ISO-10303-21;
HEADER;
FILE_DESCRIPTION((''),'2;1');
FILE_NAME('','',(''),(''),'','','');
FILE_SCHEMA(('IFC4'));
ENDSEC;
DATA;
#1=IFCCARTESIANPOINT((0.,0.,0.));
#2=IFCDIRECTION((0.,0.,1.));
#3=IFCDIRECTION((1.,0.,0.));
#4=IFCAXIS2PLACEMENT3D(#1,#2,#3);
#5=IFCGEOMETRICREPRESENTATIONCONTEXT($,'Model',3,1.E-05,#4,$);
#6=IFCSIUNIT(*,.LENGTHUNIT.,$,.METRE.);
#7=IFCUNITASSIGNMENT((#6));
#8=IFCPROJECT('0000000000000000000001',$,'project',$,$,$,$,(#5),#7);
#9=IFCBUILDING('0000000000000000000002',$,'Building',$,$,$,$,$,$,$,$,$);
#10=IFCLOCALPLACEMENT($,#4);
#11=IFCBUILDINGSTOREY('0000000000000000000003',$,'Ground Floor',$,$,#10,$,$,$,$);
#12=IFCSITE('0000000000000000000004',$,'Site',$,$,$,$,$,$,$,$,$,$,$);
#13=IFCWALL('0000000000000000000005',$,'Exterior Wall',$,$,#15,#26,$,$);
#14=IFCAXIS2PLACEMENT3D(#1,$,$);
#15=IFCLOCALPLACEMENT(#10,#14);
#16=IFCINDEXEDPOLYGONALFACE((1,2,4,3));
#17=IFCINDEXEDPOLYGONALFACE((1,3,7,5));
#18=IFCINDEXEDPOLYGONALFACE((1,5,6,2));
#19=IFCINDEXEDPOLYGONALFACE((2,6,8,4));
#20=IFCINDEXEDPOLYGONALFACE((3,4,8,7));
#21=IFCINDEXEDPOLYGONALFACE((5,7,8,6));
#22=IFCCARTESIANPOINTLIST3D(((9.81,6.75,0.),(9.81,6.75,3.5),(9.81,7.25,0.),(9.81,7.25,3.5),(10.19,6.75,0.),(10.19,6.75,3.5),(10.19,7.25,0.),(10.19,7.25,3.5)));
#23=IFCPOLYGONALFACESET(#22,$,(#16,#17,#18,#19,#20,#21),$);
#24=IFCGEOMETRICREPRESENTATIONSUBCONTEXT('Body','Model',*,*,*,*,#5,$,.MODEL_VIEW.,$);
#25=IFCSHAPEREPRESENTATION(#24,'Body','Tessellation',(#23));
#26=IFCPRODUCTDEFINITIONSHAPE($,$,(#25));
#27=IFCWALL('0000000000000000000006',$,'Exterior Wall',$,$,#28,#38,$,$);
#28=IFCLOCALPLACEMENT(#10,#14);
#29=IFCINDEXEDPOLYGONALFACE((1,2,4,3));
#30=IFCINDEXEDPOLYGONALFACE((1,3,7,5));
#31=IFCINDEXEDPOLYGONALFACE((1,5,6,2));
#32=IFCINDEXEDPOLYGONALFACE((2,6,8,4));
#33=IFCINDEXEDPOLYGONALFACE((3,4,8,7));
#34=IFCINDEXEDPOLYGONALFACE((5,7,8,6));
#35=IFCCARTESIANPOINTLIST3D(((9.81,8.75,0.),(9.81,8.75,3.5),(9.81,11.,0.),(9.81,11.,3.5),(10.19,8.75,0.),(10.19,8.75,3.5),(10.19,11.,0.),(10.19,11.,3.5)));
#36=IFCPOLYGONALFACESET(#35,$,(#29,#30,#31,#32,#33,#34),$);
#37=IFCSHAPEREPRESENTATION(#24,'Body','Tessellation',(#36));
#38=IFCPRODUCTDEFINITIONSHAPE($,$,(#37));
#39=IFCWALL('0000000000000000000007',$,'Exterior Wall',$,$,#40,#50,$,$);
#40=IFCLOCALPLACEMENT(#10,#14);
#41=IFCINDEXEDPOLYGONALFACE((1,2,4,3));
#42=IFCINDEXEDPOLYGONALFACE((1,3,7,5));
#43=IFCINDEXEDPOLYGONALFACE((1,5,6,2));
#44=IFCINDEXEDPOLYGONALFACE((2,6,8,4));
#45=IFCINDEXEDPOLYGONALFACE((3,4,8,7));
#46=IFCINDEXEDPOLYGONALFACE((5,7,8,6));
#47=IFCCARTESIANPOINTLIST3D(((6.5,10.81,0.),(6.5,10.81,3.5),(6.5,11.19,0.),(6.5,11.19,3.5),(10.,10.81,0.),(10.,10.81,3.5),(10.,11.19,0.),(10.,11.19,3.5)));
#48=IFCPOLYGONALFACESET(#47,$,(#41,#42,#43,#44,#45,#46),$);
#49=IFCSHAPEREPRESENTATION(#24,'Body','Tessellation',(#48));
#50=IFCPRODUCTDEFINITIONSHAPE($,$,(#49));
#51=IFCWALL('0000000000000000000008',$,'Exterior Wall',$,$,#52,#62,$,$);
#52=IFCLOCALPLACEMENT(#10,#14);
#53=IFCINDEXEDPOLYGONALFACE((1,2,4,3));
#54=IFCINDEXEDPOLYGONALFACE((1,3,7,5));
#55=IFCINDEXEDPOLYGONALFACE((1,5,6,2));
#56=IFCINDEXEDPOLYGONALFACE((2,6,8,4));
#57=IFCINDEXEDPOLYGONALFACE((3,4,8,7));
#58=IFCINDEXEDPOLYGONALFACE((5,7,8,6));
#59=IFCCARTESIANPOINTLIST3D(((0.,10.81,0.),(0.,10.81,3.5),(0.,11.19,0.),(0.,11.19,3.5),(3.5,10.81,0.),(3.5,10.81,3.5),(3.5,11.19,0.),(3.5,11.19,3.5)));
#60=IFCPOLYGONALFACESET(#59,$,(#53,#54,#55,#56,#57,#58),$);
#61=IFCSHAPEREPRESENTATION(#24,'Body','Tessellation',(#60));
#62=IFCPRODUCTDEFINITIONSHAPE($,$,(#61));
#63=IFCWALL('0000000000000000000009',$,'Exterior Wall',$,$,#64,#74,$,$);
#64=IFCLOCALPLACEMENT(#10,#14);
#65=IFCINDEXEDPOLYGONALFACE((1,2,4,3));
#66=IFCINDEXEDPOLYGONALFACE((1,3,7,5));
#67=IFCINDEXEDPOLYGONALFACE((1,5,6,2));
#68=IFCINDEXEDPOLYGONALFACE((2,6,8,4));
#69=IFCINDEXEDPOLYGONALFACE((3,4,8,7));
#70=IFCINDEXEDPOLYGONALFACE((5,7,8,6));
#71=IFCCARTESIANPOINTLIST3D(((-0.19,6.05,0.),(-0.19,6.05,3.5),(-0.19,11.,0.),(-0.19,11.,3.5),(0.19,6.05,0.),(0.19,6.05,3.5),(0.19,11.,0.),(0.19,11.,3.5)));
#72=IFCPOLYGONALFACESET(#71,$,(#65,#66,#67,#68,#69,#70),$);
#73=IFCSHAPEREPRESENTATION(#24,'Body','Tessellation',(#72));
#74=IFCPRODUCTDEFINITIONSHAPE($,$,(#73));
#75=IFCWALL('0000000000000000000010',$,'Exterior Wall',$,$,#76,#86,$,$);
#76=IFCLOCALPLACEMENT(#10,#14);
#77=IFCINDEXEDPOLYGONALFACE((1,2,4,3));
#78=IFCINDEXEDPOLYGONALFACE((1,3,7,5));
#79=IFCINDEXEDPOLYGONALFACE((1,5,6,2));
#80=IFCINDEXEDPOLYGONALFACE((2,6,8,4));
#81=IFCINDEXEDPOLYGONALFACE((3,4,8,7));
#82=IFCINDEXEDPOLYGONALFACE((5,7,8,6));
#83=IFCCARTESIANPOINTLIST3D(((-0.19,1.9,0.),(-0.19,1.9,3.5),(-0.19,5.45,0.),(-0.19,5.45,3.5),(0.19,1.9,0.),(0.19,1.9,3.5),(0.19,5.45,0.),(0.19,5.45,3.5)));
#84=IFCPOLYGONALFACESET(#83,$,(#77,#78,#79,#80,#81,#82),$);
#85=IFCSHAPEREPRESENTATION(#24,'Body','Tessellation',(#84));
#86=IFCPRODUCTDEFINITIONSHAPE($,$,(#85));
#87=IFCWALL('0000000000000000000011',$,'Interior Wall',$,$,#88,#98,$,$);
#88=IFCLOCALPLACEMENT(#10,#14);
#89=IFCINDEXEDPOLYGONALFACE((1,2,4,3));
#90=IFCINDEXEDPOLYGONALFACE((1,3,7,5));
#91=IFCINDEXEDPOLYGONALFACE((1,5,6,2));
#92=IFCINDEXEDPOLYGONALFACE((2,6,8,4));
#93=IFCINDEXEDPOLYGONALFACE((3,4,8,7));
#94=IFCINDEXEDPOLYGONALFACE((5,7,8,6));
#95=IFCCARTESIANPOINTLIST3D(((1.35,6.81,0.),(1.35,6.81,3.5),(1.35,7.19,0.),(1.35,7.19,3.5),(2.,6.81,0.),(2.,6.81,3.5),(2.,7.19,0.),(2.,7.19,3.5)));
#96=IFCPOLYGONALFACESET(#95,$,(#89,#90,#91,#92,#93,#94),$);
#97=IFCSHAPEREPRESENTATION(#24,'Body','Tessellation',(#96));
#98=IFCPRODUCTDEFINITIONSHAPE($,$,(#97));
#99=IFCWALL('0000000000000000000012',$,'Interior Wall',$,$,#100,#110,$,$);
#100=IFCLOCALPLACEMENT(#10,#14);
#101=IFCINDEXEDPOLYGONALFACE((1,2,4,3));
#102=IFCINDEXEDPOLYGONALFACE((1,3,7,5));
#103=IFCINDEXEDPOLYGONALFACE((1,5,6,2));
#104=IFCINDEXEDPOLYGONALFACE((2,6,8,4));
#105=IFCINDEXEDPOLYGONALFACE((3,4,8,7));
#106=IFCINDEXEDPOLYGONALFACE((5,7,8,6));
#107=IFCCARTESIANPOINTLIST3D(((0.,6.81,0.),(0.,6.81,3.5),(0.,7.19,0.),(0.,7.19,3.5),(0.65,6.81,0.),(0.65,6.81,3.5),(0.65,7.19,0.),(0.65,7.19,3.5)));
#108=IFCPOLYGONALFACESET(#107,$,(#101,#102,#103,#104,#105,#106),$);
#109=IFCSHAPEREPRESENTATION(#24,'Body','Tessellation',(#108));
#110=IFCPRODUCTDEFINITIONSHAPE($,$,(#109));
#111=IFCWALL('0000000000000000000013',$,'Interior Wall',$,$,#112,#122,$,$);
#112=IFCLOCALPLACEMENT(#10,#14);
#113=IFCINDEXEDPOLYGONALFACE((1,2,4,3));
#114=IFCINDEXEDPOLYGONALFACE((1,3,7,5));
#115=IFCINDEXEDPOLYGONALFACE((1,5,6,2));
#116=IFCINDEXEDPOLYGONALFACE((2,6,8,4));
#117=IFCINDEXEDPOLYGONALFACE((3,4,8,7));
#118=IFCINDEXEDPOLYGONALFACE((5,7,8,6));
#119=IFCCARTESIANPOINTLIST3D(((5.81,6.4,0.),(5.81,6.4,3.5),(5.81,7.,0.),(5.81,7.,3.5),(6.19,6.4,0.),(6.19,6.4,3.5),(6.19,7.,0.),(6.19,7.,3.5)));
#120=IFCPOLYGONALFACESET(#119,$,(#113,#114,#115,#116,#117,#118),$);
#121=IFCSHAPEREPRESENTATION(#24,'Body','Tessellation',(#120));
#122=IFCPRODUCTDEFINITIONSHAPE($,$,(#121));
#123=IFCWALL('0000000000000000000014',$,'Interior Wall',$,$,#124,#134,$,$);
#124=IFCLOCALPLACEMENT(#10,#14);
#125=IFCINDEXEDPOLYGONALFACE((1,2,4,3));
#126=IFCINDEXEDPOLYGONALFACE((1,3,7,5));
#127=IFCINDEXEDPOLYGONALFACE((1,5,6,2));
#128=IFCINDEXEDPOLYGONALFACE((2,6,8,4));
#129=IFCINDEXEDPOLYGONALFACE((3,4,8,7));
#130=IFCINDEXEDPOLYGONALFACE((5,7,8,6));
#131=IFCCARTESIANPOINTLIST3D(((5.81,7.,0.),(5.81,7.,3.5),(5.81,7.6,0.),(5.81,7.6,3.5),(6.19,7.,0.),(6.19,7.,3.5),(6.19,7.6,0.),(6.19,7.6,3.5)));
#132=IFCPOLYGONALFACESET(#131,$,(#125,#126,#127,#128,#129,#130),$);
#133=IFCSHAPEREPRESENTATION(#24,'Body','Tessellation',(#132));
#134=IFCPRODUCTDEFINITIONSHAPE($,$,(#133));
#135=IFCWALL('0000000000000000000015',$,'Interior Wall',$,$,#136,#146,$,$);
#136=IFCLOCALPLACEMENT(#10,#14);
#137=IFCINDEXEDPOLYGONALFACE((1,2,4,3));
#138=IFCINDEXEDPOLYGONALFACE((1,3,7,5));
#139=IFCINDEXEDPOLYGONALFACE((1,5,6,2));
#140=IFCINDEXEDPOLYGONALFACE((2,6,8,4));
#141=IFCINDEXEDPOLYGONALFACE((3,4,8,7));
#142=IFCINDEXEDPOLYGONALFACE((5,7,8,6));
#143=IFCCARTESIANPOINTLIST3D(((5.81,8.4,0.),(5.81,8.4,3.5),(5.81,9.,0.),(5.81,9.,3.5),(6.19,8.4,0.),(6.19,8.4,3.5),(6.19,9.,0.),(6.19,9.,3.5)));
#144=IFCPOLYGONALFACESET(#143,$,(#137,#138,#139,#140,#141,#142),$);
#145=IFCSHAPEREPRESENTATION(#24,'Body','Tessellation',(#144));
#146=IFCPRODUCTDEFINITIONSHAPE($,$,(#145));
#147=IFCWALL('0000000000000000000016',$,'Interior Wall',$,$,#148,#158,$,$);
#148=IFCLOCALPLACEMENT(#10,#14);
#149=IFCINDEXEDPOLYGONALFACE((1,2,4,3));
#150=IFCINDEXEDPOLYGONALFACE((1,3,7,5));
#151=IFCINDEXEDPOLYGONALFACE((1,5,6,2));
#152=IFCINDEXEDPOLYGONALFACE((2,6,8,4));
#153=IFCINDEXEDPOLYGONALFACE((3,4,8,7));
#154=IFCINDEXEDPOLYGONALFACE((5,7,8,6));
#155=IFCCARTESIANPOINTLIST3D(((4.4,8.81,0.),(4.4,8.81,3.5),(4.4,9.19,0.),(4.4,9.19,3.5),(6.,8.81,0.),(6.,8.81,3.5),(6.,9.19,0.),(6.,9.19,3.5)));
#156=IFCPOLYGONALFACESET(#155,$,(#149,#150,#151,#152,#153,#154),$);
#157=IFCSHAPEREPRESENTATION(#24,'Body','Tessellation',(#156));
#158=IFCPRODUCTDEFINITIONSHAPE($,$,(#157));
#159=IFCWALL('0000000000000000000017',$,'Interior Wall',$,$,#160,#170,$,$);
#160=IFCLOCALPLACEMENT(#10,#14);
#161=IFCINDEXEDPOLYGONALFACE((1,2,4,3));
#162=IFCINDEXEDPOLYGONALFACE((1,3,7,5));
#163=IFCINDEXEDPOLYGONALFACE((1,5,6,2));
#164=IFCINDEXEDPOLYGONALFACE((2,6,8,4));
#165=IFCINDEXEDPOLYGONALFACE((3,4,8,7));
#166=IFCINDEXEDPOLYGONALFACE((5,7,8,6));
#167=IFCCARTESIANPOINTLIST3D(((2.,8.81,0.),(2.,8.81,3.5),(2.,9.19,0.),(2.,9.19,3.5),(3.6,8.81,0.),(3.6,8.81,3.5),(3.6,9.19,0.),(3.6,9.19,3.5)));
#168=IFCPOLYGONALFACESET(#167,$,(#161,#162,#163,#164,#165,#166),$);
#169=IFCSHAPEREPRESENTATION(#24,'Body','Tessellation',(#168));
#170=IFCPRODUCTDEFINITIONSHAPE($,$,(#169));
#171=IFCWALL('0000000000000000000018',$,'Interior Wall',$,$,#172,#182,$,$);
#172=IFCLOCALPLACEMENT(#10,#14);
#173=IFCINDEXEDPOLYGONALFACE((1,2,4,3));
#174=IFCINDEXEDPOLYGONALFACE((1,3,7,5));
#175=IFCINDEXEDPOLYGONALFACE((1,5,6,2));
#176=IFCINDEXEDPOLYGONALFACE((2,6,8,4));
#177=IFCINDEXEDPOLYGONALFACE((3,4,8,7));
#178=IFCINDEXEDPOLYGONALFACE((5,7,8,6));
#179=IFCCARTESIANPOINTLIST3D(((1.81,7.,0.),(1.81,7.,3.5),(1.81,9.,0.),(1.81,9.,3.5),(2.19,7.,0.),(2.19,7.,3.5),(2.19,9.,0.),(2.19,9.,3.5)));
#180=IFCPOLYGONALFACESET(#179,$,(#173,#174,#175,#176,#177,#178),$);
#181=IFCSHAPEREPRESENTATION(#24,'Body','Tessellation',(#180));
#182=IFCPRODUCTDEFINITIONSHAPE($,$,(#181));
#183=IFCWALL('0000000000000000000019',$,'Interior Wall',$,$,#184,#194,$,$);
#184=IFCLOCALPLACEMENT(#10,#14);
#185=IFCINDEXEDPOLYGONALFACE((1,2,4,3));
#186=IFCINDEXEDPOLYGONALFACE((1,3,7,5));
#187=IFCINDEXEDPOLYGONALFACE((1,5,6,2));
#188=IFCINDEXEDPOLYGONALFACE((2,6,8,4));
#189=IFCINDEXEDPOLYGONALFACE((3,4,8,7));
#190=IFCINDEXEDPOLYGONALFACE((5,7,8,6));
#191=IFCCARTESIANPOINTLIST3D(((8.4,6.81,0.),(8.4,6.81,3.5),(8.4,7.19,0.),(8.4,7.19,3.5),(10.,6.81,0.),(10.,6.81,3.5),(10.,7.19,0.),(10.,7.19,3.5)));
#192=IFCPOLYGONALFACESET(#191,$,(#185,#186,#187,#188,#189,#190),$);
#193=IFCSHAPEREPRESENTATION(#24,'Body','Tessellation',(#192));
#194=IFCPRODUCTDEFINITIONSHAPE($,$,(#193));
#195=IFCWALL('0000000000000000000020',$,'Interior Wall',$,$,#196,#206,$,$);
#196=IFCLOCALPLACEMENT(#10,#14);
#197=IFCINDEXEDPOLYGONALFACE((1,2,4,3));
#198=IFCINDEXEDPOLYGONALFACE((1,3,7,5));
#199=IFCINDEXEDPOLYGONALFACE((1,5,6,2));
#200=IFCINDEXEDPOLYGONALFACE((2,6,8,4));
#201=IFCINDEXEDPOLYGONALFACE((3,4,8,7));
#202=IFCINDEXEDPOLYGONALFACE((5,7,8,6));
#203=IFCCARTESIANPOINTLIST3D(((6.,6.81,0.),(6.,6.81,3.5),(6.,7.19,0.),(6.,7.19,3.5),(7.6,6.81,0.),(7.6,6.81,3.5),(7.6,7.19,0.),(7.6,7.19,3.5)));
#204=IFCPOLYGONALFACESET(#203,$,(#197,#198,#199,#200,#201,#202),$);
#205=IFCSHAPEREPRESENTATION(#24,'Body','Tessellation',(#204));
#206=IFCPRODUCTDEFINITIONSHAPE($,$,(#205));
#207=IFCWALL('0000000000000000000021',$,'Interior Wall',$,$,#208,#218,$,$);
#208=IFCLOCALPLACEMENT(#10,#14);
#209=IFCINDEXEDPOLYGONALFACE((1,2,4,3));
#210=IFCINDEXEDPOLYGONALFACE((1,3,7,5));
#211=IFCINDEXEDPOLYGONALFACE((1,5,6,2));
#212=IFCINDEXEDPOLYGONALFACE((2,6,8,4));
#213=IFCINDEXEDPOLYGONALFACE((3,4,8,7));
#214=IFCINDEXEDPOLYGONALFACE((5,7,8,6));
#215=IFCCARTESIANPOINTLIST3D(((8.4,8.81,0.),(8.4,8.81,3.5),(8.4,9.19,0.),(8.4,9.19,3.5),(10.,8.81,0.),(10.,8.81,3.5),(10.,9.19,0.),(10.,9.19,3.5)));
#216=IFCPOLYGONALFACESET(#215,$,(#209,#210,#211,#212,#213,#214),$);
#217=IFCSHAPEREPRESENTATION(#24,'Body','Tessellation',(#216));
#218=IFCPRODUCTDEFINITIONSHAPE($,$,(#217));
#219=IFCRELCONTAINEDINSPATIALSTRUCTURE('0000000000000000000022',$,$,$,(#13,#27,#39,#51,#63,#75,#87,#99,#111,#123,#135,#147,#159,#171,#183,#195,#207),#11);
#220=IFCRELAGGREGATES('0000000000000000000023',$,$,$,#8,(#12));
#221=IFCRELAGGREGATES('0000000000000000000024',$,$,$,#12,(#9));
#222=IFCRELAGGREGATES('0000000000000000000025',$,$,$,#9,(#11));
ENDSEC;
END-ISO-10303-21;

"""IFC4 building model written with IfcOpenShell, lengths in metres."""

from ifc_helpers import new_model, si_unit, frame, origin_with_axes, place, context, subcontext, project, spatial, indexed_curve, outline, extrude, element, save


model = new_model("IFC4")

# Units and contexts
model_context = context("Model", 3, precision=1e-05, world=origin_with_axes())
body_context = subcontext(model_context, "Body", "Model", "MODEL_VIEW")
ifc_project = project(units=[si_unit("LENGTHUNIT", "METRE")], contexts=[model_context])

# Site, building, storey
site = spatial("IfcSite", under=ifc_project, Name="Site")
building = spatial("IfcBuilding", under=site, Name="Building")
storey_placement = place(None, origin_with_axes())
storey = spatial("IfcBuildingStorey", under=building, at=storey_placement, Name="Ground Floor")

# Walls
wall_1_placement = place(storey_placement, frame((10.0, 6.75, 0.0), z_axis=(0.0, 0.0, 1.0), x_axis=(0.0, 1.0, 0.0)))
element("IfcWall", 1, at=wall_1_placement, inside=storey, Name="Exterior Wall", context=body_context, shape_type="SweptSolid", body=[
    extrude(outline(indexed_curve([(0.0, 0.0), (0.0, 0.38), (0.5, 0.38), (0.5, 0.0), (0.0, 0.0)], self_intersect=False)), frame((0.0, -0.19, 0.0), z_axis=(0.0, 0.0, 1.0), x_axis=(1.0, 0.0, 0.0)), (0.0, 0.0, 1.0), 3.5),
])
wall_2_placement = place(storey_placement, frame((10.0, 8.75, 0.0), z_axis=(0.0, 0.0, 1.0), x_axis=(0.0, 1.0, 0.0)))
element("IfcWall", 2, at=wall_2_placement, inside=storey, Name="Exterior Wall", context=body_context, shape_type="SweptSolid", body=[
    extrude(outline(indexed_curve([(0.0, 0.0), (0.0, 0.38), (2.25, 0.38), (2.25, 0.0), (0.0, 0.0)], self_intersect=False)), frame((0.0, -0.19, 0.0), z_axis=(0.0, 0.0, 1.0), x_axis=(1.0, 0.0, 0.0)), (0.0, 0.0, 1.0), 3.5),
])
for number, where, z_axis, x_axis, name in (
    (3, (10.0, 11.0, 0.0), (0.0, 0.0, 1.0), (-1.0, 0.0, 0.0), "Exterior Wall"),
    (4, (3.5, 11.0, 0.0), (0.0, 0.0, 1.0), (-1.0, 0.0, 0.0), "Exterior Wall"),
):
    element("IfcWall", number, at=place(storey_placement, frame(where, z_axis=z_axis, x_axis=x_axis)), inside=storey, Name=name, context=body_context, shape_type="SweptSolid", body=[
        extrude(outline(indexed_curve([(0.0, 0.0), (0.0, 0.38), (3.5, 0.38), (3.5, 0.0), (0.0, 0.0)], self_intersect=False)), frame((0.0, -0.19, 0.0), z_axis=(0.0, 0.0, 1.0), x_axis=(1.0, 0.0, 0.0)), (0.0, 0.0, 1.0), 3.5),
    ])
wall_3_placement = place(storey_placement, frame((0.0, 11.0, 0.0), z_axis=(0.0, 0.0, 1.0), x_axis=(0.0, -1.0, 0.0)))
element("IfcWall", 5, at=wall_3_placement, inside=storey, Name="Exterior Wall", context=body_context, shape_type="SweptSolid", body=[
    extrude(outline(indexed_curve([(0.0, 0.0), (0.0, 0.38), (4.95, 0.38), (4.95, 0.0), (0.0, 0.0)], self_intersect=False)), frame((0.0, -0.19, 0.0), z_axis=(0.0, 0.0, 1.0), x_axis=(1.0, 0.0, 0.0)), (0.0, 0.0, 1.0), 3.5),
])
wall_4_placement = place(storey_placement, frame((0.0, 5.45, 0.0), z_axis=(0.0, 0.0, 1.0), x_axis=(0.0, -1.0, 0.0)))
element("IfcWall", 6, at=wall_4_placement, inside=storey, Name="Exterior Wall", context=body_context, shape_type="SweptSolid", body=[
    extrude(outline(indexed_curve([(0.0, 0.0), (0.0, 0.38), (3.55, 0.38), (3.55, 0.0), (0.0, 0.0)], self_intersect=False)), frame((0.0, -0.19, 0.0), z_axis=(0.0, 0.0, 1.0), x_axis=(1.0, 0.0, 0.0)), (0.0, 0.0, 1.0), 3.5),
])
for number, where, z_axis, x_axis, name in (
    (7, (2.0, 7.0, 0.0), (0.0, 0.0, 1.0), (-1.0, 0.0, 0.0), "Interior Wall"),
    (8, (0.65, 7.0, 0.0), (0.0, 0.0, 1.0), (-1.0, 0.0, 0.0), "Interior Wall"),
):
    element("IfcWall", number, at=place(storey_placement, frame(where, z_axis=z_axis, x_axis=x_axis)), inside=storey, Name=name, context=body_context, shape_type="SweptSolid", body=[
        extrude(outline(indexed_curve([(0.0, 0.0), (0.0, 0.38), (0.65, 0.38), (0.65, 0.0), (0.0, 0.0)], self_intersect=False)), frame((0.0, -0.19, 0.0), z_axis=(0.0, 0.0, 1.0), x_axis=(1.0, 0.0, 0.0)), (0.0, 0.0, 1.0), 3.5),
    ])
for number, where, z_axis, x_axis, name in (
    (9, (6.0, 6.4, 0.0), (0.0, 0.0, 1.0), (0.0, 1.0, 0.0), "Interior Wall"),
    (10, (6.0, 7.0, 0.0), (0.0, 0.0, 1.0), (0.0, 1.0, 0.0), "Interior Wall"),
    (11, (6.0, 8.4, 0.0), (0.0, 0.0, 1.0), (0.0, 1.0, 0.0), "Interior Wall"),
):
    element("IfcWall", number, at=place(storey_placement, frame(where, z_axis=z_axis, x_axis=x_axis)), inside=storey, Name=name, context=body_context, shape_type="SweptSolid", body=[
        extrude(outline(indexed_curve([(0.0, 0.0), (0.0, 0.38), (0.6, 0.38), (0.6, 0.0), (0.0, 0.0)], self_intersect=False)), frame((0.0, -0.19, 0.0), z_axis=(0.0, 0.0, 1.0), x_axis=(1.0, 0.0, 0.0)), (0.0, 0.0, 1.0), 3.5),
    ])
wall_5_placement = place(storey_placement, frame((6.0, 9.0, 0.0), z_axis=(0.0, 0.0, 1.0), x_axis=(-1.0, 0.0, 0.0)))
element("IfcWall", 12, at=wall_5_placement, inside=storey, Name="Interior Wall", context=body_context, shape_type="SweptSolid", body=[
    extrude(outline(indexed_curve([(0.0, 0.0), (0.0, 0.38), (1.6, 0.38), (1.6, 0.0), (0.0, 0.0)], self_intersect=False)), frame((0.0, -0.19, 0.0), z_axis=(0.0, 0.0, 1.0), x_axis=(1.0, 0.0, 0.0)), (0.0, 0.0, 1.0), 3.5),
])
wall_6_placement = place(storey_placement, frame((3.6, 9.0, 0.0), z_axis=(0.0, 0.0, 1.0), x_axis=(-1.0, 0.0, 0.0)))
element("IfcWall", 13, at=wall_6_placement, inside=storey, Name="Interior Wall", context=body_context, shape_type="SweptSolid", body=[
    extrude(outline(indexed_curve([(0.0, 0.0), (0.0, 0.38), (1.6, 0.38), (1.6, 0.0), (0.0, 0.0)], self_intersect=False)), frame((0.0, -0.19, 0.0), z_axis=(0.0, 0.0, 1.0), x_axis=(1.0, 0.0, 0.0)), (0.0, 0.0, 1.0), 3.5),
])
wall_7_placement = place(storey_placement, frame((2.0, 9.0, 0.0), z_axis=(0.0, 0.0, 1.0), x_axis=(0.0, -1.0, 0.0)))
element("IfcWall", 14, at=wall_7_placement, inside=storey, Name="Interior Wall", context=body_context, shape_type="SweptSolid", body=[
    extrude(outline(indexed_curve([(0.0, 0.0), (0.0, 0.38), (2.0, 0.38), (2.0, 0.0), (0.0, 0.0)], self_intersect=False)), frame((0.0, -0.19, 0.0), z_axis=(0.0, 0.0, 1.0), x_axis=(1.0, 0.0, 0.0)), (0.0, 0.0, 1.0), 3.5),
])
for number, where, z_axis, x_axis, name in (
    (15, (10.0, 7.0, 0.0), (0.0, 0.0, 1.0), (-1.0, 0.0, 0.0), "Interior Wall"),
    (16, (7.6, 7.0, 0.0), (0.0, 0.0, 1.0), (-1.0, 0.0, 0.0), "Interior Wall"),
    (17, (10.0, 9.0, 0.0), (0.0, 0.0, 1.0), (-1.0, 0.0, 0.0), "Interior Wall"),
):
    element("IfcWall", number, at=place(storey_placement, frame(where, z_axis=z_axis, x_axis=x_axis)), inside=storey, Name=name, context=body_context, shape_type="SweptSolid", body=[
        extrude(outline(indexed_curve([(0.0, 0.0), (0.0, 0.38), (1.6, 0.38), (1.6, 0.0), (0.0, 0.0)], self_intersect=False)), frame((0.0, -0.19, 0.0), z_axis=(0.0, 0.0, 1.0), x_axis=(1.0, 0.0, 0.0)), (0.0, 0.0, 1.0), 3.5),
    ])

save(model, "model.ifc")
